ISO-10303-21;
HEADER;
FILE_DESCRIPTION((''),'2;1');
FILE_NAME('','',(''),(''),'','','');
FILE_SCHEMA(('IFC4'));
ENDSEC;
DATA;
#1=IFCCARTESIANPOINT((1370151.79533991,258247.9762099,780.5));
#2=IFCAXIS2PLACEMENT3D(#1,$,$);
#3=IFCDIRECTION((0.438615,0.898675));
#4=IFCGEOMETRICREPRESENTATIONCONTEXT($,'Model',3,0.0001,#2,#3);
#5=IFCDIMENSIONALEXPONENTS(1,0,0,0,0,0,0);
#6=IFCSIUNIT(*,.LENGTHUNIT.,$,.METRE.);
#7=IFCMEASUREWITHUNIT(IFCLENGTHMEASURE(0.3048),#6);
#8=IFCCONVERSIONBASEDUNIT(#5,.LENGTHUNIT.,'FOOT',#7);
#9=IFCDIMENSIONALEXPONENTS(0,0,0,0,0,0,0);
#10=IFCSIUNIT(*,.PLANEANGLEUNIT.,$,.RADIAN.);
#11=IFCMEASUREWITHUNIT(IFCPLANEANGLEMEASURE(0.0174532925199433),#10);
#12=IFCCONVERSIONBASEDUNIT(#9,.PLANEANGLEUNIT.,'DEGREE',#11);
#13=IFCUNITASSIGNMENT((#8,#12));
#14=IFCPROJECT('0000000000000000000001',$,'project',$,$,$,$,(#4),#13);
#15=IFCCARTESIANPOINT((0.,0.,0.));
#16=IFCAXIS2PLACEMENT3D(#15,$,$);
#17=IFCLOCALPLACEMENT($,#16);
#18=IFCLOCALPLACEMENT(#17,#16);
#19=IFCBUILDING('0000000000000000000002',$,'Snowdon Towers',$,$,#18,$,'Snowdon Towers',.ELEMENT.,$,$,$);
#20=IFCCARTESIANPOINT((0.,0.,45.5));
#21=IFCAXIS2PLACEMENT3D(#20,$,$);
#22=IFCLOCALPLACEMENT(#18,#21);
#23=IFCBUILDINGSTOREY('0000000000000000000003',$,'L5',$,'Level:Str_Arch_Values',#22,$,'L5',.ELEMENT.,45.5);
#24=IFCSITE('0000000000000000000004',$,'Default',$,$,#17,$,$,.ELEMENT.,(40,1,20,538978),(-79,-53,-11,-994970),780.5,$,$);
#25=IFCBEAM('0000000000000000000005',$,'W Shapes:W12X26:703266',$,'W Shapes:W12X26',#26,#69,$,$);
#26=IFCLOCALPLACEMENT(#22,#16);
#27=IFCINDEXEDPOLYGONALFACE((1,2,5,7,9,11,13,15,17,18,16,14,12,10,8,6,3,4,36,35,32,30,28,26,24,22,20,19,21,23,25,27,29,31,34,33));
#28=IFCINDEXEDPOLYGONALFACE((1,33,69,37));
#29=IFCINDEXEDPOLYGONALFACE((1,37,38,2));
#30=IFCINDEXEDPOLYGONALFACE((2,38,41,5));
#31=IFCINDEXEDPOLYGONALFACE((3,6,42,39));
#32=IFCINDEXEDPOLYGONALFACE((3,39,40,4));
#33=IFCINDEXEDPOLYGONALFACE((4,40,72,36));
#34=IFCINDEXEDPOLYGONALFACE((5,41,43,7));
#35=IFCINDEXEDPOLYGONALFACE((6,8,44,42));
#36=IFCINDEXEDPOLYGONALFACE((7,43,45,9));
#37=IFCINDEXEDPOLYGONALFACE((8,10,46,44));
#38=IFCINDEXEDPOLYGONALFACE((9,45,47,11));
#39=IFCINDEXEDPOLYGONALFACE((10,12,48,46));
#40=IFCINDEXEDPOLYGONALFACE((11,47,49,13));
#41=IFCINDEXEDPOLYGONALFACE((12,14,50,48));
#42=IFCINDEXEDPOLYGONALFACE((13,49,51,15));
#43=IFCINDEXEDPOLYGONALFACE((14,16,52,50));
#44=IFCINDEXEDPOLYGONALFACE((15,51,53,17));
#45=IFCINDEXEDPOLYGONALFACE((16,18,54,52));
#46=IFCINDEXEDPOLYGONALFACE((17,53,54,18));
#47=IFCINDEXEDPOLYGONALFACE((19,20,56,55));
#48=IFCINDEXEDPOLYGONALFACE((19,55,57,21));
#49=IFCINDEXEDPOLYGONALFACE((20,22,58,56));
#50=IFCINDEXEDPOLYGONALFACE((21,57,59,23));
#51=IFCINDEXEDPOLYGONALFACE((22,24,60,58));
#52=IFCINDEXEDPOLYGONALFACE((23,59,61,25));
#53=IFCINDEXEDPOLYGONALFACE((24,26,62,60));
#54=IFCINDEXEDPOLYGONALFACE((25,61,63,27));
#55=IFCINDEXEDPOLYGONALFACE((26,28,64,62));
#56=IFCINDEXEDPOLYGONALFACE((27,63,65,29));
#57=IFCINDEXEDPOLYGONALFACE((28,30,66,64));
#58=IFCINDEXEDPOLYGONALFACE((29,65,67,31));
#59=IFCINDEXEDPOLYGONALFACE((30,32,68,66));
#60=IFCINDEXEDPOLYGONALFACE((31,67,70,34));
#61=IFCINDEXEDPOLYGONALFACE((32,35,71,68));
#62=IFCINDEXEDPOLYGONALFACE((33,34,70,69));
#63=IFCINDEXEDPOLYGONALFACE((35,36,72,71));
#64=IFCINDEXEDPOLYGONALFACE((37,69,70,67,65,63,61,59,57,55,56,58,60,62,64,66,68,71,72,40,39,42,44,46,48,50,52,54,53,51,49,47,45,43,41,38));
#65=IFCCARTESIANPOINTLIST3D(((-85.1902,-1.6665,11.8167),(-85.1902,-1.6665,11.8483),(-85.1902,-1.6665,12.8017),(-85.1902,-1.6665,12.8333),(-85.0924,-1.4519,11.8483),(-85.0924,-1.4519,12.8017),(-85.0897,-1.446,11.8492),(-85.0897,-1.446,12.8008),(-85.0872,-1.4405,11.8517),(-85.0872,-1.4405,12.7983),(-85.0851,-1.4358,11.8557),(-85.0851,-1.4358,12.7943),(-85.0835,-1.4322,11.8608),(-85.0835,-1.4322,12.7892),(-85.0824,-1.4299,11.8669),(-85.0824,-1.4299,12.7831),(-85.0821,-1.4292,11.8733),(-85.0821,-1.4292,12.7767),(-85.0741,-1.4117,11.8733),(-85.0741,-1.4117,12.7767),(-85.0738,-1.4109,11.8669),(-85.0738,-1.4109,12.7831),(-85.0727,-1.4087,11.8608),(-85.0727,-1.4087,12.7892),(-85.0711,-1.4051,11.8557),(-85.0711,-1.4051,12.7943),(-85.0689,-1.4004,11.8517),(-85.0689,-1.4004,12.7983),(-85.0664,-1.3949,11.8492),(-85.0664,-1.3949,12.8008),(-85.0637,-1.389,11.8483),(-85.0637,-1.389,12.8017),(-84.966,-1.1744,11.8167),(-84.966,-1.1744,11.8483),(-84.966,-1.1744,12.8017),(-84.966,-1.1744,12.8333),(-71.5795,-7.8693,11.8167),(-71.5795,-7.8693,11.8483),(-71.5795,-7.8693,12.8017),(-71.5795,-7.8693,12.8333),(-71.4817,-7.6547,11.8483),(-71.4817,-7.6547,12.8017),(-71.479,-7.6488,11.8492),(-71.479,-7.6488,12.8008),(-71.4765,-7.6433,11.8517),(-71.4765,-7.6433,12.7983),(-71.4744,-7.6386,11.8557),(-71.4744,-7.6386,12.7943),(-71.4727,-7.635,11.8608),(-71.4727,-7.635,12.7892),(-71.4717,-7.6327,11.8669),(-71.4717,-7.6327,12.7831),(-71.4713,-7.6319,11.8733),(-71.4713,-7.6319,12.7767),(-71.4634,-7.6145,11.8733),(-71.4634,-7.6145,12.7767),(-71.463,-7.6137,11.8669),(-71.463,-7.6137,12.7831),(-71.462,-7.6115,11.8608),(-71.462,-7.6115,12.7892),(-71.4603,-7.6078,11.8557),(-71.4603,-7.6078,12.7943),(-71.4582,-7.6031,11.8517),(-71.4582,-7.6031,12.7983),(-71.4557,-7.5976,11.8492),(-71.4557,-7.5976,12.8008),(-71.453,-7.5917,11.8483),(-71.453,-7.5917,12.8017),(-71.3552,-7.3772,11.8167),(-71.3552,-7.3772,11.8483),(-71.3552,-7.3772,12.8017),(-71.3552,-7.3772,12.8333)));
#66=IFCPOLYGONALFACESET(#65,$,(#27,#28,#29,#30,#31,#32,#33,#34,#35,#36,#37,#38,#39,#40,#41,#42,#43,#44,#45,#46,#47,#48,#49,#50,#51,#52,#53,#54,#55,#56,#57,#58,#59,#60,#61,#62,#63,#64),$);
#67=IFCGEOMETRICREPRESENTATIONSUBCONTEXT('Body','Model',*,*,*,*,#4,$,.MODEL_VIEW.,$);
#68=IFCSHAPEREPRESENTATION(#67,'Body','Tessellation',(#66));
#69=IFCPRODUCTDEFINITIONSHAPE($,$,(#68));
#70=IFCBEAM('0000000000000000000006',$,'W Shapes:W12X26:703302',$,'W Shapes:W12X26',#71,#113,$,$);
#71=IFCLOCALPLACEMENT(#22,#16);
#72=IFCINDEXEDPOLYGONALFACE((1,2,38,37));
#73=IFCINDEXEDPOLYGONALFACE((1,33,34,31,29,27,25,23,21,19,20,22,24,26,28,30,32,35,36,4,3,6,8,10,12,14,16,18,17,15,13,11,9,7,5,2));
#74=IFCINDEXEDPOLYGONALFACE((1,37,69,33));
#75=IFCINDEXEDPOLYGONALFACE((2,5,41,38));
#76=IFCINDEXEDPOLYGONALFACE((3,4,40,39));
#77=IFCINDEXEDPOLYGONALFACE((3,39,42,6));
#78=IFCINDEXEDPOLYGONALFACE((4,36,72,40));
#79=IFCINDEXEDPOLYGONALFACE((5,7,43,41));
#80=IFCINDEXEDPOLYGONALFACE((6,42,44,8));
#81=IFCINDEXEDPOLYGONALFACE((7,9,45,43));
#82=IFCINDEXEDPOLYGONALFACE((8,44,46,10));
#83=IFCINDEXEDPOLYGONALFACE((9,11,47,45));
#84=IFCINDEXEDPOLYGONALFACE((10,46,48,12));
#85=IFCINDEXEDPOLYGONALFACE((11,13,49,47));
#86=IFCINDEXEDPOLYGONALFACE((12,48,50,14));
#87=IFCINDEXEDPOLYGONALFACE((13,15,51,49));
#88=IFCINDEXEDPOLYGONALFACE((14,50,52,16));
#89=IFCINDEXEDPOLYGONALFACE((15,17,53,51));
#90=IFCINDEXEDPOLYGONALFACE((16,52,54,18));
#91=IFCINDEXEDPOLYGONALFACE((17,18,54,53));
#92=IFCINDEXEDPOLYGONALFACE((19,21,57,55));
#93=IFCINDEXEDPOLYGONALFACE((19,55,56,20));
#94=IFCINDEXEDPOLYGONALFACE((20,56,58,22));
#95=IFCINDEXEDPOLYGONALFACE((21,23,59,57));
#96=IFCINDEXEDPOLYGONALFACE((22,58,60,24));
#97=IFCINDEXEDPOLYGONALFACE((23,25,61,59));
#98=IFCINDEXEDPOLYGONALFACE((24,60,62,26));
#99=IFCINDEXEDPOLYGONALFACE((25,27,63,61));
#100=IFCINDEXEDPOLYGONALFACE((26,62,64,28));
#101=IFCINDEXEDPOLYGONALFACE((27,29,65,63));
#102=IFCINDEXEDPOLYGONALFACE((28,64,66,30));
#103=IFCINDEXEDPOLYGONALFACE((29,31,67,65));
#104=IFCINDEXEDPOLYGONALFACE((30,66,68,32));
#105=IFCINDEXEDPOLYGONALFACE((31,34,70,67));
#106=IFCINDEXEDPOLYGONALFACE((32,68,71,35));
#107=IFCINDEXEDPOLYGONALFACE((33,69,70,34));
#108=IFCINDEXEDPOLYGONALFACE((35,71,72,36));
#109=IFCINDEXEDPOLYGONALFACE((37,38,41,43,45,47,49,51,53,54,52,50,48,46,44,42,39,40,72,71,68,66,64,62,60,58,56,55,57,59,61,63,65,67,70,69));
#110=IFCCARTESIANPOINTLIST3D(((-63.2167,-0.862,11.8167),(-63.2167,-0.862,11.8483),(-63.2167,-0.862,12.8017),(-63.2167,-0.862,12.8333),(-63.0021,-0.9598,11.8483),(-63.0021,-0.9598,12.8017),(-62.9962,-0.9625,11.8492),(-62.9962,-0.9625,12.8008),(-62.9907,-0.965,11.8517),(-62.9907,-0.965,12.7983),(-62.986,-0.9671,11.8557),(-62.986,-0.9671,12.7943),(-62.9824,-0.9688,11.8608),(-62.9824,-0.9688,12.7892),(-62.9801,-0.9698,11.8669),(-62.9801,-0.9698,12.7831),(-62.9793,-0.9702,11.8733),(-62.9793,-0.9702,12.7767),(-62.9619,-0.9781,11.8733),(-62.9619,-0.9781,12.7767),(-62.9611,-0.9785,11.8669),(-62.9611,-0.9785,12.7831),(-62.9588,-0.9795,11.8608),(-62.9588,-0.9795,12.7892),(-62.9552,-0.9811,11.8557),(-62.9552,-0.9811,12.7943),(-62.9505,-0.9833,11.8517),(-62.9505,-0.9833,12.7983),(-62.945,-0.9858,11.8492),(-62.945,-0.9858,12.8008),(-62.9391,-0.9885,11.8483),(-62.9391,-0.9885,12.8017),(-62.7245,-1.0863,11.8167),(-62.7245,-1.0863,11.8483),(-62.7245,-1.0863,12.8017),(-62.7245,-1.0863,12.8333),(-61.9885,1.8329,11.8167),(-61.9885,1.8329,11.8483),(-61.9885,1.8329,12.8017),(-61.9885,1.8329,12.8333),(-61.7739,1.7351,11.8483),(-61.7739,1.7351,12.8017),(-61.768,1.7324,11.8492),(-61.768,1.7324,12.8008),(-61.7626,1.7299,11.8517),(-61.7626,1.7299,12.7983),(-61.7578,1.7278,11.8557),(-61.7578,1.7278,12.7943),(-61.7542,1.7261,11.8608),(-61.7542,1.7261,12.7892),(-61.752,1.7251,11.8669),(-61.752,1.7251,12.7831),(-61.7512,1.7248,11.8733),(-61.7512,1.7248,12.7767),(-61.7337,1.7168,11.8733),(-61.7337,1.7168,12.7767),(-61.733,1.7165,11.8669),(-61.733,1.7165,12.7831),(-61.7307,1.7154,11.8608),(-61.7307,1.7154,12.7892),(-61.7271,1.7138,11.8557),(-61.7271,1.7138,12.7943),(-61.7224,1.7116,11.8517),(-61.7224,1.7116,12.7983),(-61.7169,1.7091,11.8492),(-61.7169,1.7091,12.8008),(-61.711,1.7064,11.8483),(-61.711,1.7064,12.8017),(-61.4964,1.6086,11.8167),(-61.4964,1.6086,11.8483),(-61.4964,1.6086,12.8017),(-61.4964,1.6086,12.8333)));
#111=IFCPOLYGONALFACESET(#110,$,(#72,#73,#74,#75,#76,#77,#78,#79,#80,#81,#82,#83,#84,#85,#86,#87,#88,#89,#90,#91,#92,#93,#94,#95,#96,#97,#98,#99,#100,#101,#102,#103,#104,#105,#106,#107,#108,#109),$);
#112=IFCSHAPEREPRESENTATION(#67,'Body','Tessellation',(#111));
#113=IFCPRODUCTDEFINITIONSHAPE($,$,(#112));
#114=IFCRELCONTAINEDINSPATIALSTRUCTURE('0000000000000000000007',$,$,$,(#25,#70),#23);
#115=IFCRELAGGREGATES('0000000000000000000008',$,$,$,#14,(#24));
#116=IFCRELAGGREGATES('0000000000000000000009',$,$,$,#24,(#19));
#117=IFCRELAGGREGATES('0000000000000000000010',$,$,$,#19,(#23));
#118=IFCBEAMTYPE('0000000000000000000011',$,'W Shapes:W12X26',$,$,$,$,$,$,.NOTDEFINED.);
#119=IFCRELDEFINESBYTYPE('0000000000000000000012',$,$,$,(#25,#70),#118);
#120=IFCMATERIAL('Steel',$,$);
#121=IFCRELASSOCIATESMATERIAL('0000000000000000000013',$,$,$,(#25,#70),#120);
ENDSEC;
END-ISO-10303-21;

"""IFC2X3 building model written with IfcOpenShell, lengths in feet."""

from ifc_helpers import new_model, entity, si_unit, converted_unit, direction, frame, frame_2d, origin, place, context, subcontext, project, spatial, i_section, extrude, material, type_object, element, save


model = new_model("IFC2X3")

# Units and contexts
model_context = context("Model", 3, precision=0.0001, world=frame((1370151.79533991, 258247.9762099, 780.5)), true_north=direction((0.438615, 0.898675)))
body_context = subcontext(model_context, "Body", "Model", "MODEL_VIEW")
ifc_project = project(units=[converted_unit("LENGTHUNIT", "FOOT", entity("IfcLengthMeasure", 0.3048), si_unit("LENGTHUNIT", "METRE"), dimensions=[1, 0, 0, 0, 0, 0, 0]), converted_unit("PLANEANGLEUNIT", "DEGREE", entity("IfcPlaneAngleMeasure", 0.0174532925199433), si_unit("PLANEANGLEUNIT", "RADIAN"), dimensions=[0, 0, 0, 0, 0, 0, 0])], contexts=[model_context])

# Site, building, storey
site_placement = place(None, origin())
site = spatial("IfcSite", under=ifc_project, at=site_placement, Name="Default", CompositionType="ELEMENT", RefLatitude=(40, 1, 20, 538978), RefLongitude=(-79, -53, -11, -994970), RefElevation=780.5)
building_placement = place(site_placement, origin())
building = spatial("IfcBuilding", under=site, at=building_placement, Name="Snowdon Towers", LongName="Snowdon Towers", CompositionType="ELEMENT")
storey_placement = place(building_placement, frame((0.0, 0.0, 45.5)))
storey = spatial("IfcBuildingStorey", under=building, at=storey_placement, Name="L5", ObjectType="Level:Str_Arch_Values", LongName="L5", CompositionType="ELEMENT", Elevation=45.5)

# Shared definitions
ifc_material = material(Name="Steel")

# Beams
beam_type_1 = type_object("IfcBeamType", Name="W Shapes:W12X26", PredefinedType="NOTDEFINED")
beam_1_placement = place(storey_placement, frame((-84.832, -1.5326, 12.8333), z_axis=(0.0, 0.0, 1.0), x_axis=(0.909961, -0.414693, 0.0)))
element("IfcBeam", 1, at=beam_1_placement, inside=storey, type_object=beam_type_1, material=ifc_material, Name="W Shapes:W12X26:703266", ObjectType="W Shapes:W12X26", context=body_context, shape_type="SweptSolid", body=[
    extrude(i_section(OverallWidth=0.5408, OverallDepth=1.0167, WebThickness=0.0192, FlangeThickness=0.0317, FilletRadius=0.025, at=frame_2d((0.0, 0.0), x_axis=(0.0, 1.0))), frame((-0.2704, 0.0, -0.5083), z_axis=(1.0, 0.0, 0.0), x_axis=(0.0, 0.0, -1.0)), (0.0, 0.0, 1.0), 14.9575),
])
beam_2_placement = place(storey_placement, frame((-63.1, -1.2581, 12.8333), z_axis=(0.0, 0.0, 1.0), x_axis=(0.414693, 0.909961, 0.0)))
element("IfcBeam", 2, at=beam_2_placement, inside=storey, type_object=beam_type_1, material=ifc_material, Name="W Shapes:W12X26:703302", ObjectType="W Shapes:W12X26", context=body_context, shape_type="SweptSolid", body=[
    extrude(i_section(OverallWidth=0.5408, OverallDepth=1.0167, WebThickness=0.0192, FlangeThickness=0.0317, FilletRadius=0.025, at=frame_2d((0.0, 0.0), x_axis=(0.0, 1.0))), frame((0.3121, 0.0, -0.5083), z_axis=(1.0, 0.0, 0.0), x_axis=(0.0, 0.0, -1.0)), (0.0, 0.0, 1.0), 2.9616),
])

save(model, "model.ifc")
